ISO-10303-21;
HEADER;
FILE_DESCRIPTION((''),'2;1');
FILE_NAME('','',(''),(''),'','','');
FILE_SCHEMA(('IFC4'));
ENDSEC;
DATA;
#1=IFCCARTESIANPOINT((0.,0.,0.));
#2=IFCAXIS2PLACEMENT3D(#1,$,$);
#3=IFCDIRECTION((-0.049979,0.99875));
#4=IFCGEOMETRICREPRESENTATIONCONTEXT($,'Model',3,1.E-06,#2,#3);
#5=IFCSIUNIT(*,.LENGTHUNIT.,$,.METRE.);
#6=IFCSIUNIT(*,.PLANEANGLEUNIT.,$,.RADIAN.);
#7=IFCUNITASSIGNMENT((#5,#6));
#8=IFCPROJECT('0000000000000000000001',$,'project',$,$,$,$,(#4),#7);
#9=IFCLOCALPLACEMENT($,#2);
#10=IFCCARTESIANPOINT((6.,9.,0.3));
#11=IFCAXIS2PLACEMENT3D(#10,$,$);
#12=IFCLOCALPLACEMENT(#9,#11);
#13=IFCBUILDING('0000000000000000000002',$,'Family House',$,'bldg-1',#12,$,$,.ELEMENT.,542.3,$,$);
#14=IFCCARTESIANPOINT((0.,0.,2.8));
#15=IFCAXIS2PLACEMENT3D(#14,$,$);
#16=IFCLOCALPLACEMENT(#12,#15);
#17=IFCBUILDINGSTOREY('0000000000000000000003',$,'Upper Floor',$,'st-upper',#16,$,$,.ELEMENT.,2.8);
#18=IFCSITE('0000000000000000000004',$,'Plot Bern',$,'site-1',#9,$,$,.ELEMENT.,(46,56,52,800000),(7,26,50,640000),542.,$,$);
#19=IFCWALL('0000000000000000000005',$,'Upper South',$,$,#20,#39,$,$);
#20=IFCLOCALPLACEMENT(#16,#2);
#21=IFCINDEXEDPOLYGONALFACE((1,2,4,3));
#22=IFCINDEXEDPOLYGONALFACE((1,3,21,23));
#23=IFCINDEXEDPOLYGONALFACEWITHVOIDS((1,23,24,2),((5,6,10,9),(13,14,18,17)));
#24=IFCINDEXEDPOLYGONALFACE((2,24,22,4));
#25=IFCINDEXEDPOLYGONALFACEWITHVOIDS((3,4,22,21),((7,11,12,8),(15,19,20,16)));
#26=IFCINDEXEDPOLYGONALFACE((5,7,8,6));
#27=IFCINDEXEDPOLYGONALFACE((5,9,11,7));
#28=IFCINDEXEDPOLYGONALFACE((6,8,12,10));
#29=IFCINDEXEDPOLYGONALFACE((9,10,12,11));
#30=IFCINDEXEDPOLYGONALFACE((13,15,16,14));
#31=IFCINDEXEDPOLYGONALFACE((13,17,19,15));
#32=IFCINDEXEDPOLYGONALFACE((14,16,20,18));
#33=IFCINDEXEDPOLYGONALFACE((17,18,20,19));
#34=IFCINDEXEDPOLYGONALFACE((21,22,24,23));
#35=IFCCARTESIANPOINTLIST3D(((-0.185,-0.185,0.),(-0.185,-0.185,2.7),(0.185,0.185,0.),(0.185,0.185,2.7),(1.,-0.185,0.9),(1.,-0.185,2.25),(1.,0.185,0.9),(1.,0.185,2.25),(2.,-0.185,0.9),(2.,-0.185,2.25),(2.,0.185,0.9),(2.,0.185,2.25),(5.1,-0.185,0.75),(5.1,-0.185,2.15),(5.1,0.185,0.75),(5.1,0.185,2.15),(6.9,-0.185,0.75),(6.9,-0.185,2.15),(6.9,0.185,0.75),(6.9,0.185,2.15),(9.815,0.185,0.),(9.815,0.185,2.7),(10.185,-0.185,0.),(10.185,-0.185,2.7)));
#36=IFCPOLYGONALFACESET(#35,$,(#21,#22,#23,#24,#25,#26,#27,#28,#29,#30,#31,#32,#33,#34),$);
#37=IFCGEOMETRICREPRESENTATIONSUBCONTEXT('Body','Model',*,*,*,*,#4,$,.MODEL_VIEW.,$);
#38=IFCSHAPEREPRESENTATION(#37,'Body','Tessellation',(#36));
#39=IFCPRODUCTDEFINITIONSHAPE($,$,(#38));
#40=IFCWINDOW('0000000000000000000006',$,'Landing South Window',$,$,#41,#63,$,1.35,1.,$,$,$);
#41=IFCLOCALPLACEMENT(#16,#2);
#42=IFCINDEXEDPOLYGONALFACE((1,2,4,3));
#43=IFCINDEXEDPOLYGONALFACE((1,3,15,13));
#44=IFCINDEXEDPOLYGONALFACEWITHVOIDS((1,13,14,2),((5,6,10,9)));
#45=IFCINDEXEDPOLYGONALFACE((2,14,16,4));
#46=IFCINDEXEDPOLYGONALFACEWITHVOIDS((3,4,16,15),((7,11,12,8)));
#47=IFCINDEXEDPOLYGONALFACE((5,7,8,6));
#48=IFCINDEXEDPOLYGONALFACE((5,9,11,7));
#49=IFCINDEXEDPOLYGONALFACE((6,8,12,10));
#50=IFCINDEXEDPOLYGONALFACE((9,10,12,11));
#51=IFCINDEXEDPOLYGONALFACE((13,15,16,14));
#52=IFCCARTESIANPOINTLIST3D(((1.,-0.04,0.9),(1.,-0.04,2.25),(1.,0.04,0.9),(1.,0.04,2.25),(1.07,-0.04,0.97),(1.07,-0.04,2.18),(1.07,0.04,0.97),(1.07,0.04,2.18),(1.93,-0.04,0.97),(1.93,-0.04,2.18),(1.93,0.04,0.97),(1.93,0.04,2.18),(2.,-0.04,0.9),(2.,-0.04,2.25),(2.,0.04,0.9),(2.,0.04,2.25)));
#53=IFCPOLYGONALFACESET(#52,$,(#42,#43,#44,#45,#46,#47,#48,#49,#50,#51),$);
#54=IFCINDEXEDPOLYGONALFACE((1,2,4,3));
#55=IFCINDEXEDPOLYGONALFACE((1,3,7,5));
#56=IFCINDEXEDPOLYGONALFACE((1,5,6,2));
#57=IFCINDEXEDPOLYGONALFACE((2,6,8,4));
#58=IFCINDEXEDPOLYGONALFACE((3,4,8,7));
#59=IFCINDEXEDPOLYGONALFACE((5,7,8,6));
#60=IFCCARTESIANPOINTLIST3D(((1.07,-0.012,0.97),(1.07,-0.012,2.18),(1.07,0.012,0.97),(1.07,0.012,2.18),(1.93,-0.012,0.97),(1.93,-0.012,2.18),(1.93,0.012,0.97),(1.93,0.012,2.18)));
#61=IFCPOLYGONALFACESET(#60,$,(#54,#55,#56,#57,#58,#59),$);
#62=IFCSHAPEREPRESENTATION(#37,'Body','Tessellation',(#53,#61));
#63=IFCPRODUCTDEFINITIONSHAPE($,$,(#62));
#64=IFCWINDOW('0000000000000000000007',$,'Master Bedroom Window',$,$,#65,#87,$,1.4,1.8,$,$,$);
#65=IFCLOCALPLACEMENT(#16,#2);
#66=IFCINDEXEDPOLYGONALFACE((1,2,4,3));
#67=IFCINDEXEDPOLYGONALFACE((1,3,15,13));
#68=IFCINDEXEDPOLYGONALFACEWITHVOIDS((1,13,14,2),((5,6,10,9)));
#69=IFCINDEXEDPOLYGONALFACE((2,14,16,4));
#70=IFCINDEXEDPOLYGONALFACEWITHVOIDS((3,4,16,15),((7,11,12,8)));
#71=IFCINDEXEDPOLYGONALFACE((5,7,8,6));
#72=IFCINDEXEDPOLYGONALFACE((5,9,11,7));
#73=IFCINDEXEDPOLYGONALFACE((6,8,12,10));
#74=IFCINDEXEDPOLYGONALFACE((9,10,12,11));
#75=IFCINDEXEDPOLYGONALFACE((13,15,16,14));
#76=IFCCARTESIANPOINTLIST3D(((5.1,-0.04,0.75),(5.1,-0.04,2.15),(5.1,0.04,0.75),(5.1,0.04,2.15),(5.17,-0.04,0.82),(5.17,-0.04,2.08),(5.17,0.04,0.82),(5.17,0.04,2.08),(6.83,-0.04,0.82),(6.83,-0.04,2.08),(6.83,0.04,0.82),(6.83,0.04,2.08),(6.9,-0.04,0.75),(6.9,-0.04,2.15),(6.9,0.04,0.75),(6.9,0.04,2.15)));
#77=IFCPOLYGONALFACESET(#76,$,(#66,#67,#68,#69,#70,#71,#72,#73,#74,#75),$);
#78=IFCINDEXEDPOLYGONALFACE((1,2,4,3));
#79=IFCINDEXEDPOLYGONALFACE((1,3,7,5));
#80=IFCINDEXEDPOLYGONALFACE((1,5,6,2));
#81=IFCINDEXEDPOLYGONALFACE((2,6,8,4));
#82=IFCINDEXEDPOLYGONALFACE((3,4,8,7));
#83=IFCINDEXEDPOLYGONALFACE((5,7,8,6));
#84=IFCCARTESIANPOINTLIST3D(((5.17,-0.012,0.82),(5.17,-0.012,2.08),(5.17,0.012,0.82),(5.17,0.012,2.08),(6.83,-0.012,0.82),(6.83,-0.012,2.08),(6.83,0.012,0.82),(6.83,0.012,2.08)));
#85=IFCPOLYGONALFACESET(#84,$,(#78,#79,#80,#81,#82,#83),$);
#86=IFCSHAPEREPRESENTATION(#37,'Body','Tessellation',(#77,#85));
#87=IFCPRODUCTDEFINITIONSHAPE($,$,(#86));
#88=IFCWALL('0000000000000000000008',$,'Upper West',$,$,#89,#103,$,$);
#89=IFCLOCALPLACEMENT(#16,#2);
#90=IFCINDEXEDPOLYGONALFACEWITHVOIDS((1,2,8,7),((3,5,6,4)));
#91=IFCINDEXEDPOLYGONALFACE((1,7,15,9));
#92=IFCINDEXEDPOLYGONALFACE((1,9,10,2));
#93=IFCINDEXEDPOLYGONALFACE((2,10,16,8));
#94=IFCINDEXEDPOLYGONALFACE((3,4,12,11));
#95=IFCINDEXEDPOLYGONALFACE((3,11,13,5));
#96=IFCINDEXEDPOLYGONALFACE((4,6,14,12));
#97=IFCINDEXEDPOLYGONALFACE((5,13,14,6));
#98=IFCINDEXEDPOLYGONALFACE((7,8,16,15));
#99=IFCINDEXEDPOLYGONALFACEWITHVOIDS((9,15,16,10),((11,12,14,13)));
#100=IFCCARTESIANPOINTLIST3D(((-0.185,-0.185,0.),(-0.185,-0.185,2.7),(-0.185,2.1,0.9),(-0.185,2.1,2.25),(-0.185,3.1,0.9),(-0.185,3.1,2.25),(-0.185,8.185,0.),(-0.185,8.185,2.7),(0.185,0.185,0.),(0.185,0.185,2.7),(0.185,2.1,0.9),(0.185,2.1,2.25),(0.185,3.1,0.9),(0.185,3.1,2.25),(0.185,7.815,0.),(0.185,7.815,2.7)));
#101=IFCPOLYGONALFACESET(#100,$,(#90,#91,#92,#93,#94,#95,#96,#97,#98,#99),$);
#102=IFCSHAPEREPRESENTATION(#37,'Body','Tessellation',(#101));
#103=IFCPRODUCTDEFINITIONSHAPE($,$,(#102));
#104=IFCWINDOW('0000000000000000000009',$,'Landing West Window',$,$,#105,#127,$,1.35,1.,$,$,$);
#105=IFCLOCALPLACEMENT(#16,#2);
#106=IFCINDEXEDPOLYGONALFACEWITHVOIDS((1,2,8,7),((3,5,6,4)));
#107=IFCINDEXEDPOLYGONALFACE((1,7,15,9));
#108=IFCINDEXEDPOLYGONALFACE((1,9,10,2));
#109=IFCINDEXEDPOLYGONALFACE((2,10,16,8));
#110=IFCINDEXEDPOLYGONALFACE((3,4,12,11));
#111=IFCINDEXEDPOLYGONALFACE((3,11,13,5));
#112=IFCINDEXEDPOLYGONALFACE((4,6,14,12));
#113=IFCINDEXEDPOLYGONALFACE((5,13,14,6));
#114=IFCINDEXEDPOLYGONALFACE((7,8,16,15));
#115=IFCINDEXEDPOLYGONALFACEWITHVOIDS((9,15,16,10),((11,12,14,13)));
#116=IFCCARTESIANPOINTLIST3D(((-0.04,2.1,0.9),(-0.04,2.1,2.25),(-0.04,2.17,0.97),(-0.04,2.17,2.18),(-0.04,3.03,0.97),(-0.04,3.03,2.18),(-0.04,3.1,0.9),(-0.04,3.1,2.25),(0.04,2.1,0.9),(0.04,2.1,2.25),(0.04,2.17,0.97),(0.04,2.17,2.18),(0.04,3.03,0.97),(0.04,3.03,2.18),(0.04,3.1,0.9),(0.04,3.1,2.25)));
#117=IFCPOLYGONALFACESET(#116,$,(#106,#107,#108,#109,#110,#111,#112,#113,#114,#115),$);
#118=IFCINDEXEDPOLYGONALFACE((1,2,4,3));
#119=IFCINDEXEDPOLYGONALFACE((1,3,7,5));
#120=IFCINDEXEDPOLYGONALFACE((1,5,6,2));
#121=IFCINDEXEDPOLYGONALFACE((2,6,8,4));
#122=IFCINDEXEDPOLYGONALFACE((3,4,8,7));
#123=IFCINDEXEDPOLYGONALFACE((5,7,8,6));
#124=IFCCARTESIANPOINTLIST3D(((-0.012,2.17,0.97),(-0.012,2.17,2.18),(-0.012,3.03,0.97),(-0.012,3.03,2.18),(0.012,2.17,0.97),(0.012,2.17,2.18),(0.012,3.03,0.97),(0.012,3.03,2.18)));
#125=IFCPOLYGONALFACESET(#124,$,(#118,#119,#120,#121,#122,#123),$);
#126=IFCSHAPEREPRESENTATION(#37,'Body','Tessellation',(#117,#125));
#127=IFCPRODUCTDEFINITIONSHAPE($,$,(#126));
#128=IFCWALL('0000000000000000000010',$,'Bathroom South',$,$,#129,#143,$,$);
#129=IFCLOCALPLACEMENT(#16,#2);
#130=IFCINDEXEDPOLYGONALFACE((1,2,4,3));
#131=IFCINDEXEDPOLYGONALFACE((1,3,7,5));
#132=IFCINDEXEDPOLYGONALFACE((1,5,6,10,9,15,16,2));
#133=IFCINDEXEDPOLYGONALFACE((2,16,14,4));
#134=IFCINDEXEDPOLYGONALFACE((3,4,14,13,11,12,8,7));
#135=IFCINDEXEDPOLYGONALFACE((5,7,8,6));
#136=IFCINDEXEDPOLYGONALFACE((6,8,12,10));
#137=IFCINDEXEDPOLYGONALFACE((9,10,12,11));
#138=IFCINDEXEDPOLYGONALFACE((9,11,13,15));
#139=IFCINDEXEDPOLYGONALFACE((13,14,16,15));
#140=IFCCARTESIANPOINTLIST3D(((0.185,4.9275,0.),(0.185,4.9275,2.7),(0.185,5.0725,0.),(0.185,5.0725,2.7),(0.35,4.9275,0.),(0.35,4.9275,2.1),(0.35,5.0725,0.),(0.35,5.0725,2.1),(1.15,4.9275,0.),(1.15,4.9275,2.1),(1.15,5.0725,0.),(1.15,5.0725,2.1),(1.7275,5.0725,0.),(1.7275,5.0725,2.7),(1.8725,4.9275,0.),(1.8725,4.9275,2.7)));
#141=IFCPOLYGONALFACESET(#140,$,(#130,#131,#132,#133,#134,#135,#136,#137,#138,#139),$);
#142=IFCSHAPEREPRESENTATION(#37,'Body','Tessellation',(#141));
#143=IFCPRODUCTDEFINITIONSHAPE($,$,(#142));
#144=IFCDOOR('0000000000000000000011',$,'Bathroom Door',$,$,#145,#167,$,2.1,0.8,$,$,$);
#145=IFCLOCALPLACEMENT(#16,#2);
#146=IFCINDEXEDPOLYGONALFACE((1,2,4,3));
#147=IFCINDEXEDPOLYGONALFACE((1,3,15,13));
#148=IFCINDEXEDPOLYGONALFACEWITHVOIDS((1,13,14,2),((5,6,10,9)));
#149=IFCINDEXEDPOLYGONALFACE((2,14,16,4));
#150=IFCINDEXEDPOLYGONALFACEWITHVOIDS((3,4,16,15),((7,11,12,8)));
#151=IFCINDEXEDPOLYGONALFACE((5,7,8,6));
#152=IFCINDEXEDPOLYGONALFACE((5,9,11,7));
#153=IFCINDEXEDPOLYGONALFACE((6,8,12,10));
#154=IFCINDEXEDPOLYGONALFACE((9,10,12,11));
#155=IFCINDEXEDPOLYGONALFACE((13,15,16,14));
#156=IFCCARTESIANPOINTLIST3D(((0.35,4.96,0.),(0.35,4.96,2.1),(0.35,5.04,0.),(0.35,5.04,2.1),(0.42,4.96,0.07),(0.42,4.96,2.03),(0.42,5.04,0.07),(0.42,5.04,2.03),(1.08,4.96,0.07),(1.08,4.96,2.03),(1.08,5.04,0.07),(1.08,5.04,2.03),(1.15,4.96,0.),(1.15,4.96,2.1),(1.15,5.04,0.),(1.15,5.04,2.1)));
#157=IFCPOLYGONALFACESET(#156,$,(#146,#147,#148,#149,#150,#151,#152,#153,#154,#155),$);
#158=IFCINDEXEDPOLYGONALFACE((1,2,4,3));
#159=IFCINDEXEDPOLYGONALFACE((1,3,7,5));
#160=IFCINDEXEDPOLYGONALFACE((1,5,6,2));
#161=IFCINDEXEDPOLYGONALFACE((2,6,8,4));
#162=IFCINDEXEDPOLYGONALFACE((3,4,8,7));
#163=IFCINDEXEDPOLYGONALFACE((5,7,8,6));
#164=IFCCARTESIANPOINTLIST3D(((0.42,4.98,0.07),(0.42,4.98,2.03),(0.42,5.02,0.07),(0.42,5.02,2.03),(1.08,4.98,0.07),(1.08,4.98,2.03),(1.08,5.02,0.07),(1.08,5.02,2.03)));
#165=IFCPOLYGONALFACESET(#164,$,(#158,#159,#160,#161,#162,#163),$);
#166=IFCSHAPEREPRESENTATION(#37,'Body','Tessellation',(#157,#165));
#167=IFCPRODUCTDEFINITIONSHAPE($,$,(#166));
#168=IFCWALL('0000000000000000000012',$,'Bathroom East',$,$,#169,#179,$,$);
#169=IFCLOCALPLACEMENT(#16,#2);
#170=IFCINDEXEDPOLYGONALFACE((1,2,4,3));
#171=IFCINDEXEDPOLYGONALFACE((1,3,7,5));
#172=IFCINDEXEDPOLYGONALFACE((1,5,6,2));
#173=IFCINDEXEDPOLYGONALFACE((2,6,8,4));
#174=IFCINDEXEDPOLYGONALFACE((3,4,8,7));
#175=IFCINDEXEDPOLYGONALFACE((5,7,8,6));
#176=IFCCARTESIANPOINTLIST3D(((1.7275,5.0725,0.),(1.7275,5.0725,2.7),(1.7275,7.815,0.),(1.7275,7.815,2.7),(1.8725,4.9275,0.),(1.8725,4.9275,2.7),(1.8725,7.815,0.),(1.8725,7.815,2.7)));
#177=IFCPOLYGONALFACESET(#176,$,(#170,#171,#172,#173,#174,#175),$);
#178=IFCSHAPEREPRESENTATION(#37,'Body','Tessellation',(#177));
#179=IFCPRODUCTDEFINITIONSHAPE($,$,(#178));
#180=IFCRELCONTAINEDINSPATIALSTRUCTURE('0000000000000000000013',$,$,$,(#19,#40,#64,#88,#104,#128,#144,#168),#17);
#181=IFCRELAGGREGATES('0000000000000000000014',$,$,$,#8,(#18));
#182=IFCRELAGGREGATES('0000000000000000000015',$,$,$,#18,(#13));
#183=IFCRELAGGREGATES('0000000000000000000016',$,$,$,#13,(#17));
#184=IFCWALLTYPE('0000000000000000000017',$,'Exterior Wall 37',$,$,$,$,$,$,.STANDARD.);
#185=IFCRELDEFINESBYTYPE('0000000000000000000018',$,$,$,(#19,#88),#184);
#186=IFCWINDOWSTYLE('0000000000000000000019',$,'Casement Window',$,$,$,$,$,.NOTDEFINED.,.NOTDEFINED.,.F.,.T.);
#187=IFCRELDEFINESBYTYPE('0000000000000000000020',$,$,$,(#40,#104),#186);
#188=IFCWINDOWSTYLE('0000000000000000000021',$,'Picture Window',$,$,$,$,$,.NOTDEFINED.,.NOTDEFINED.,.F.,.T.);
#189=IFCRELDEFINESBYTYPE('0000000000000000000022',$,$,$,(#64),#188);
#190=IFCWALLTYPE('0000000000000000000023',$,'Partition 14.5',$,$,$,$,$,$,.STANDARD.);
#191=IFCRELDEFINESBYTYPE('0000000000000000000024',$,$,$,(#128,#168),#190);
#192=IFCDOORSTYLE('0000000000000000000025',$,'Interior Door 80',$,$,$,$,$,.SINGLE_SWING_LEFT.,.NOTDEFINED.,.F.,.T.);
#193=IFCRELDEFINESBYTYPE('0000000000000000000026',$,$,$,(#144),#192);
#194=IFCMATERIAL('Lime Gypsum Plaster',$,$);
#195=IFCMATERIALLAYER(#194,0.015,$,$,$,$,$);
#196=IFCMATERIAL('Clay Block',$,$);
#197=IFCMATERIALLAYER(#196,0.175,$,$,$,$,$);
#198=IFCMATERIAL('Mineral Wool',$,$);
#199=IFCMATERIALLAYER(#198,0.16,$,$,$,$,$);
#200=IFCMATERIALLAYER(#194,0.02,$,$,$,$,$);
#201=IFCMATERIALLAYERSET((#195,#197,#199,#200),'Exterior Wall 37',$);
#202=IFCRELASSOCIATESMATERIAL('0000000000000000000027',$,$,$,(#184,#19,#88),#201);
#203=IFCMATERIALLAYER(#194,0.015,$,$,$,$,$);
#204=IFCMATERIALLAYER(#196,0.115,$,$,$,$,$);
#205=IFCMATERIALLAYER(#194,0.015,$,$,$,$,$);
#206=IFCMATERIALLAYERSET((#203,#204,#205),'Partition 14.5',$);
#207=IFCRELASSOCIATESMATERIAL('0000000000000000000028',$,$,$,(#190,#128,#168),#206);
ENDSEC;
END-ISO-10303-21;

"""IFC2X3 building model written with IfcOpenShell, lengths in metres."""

from ifc_helpers import new_model, si_unit, direction, frame, frame_2d, origin, origin_2d, place, context, subcontext, project, spatial, polyline, rectangle, outline, extrude, material, layer, layer_set, layer_usage, type_object, element, fill, save


model = new_model("IFC2X3")

# Units and contexts
model_context = context("Model", 3, precision=1e-06, world=origin(), true_north=direction((-0.049979, 0.99875)))
body_context = subcontext(model_context, "Body", "Model", "MODEL_VIEW")
ifc_project = project(units=[si_unit("LENGTHUNIT", "METRE"), si_unit("PLANEANGLEUNIT", "RADIAN")], contexts=[model_context])

# Site, building, storey
site_placement = place(None, origin())
site = spatial("IfcSite", under=ifc_project, at=site_placement, Name="Plot Bern", ObjectType="site-1", CompositionType="ELEMENT", RefLatitude=(46, 56, 52, 800000), RefLongitude=(7, 26, 50, 640000), RefElevation=542.0)
building_placement = place(site_placement, frame((6.0, 9.0, 0.3)))
building = spatial("IfcBuilding", under=site, at=building_placement, Name="Family House", ObjectType="bldg-1", CompositionType="ELEMENT", ElevationOfRefHeight=542.3)
storey_placement = place(building_placement, frame((0.0, 0.0, 2.8)))
storey = spatial("IfcBuildingStorey", under=building, at=storey_placement, Name="Upper Floor", ObjectType="st-upper", CompositionType="ELEMENT", Elevation=2.8)

# Shared definitions
ifc_material_1 = material(Name="Mineral Wool")

# Shared definitions
ifc_material_2 = material(Name="Lime Gypsum Plaster")
ifc_layer_1 = layer(ifc_material_2, 0.015)
ifc_material_3 = material(Name="Clay Block")
ifc_layer_2 = layer(ifc_material_3, 0.175)
ifc_layer_3 = layer(ifc_material_1, 0.16)
ifc_layer_4 = layer(ifc_material_2, 0.02)
ifc_layer_set_1 = layer_set([ifc_layer_1, ifc_layer_2, ifc_layer_3, ifc_layer_4], Name="Exterior Wall 37")
wall_type_1 = type_object("IfcWallType", Name="Exterior Wall 37", PredefinedType="STANDARD", material=ifc_layer_set_1)

# Shared definitions
window_style_1 = type_object("IfcWindowStyle", Name="Casement Window", ConstructionType="NOTDEFINED", OperationType="NOTDEFINED", ParameterTakesPrecedence=False, Sizeable=True)

# Wall, openings, windows
ifc_layer_usage_1 = layer_usage(ifc_layer_set_1, "AXIS2", "NEGATIVE", 0.185)
wall_1_placement = place(storey_placement, origin())
wall_1 = element("IfcWall", 1, at=wall_1_placement, inside=storey, type_object=wall_type_1, material=ifc_layer_usage_1, Name="Upper South", context=body_context, shape_type="SweptSolid", body=[
    extrude(outline(polyline([(-0.185, -0.185), (10.185, -0.185), (9.815, 0.185), (0.185, 0.185), (-0.185, -0.185)])), origin(), (0.0, 0.0, 1.0), 2.7),
])
opening_1_placement = place(wall_1_placement, frame((1.5, 0.0, 0.9), z_axis=(0.0, 0.0, 1.0), x_axis=(1.0, 0.0, 0.0)))
opening_1 = element("IfcOpeningElement", 2, at=opening_1_placement, cuts=wall_1, context=body_context, shape_type="SweptSolid", body=[
    extrude(rectangle(XDim=1.0, YDim=0.37, at=origin_2d()), origin(), (0.0, 0.0, 1.0), 1.35),
])
opening_2_placement = place(wall_1_placement, frame((6.0, 0.0, 0.75), z_axis=(0.0, 0.0, 1.0), x_axis=(1.0, 0.0, 0.0)))
opening_2 = element("IfcOpeningElement", 3, at=opening_2_placement, cuts=wall_1, context=body_context, shape_type="SweptSolid", body=[
    extrude(rectangle(XDim=1.8, YDim=0.37, at=origin_2d()), origin(), (0.0, 0.0, 1.0), 1.4),
])
window_1_placement = place(opening_1_placement, frame((0.0, 0.0, 0.0), z_axis=(0.0, -1.0, 0.0), x_axis=(1.0, 0.0, 0.0)))
window_1 = element("IfcWindow", 4, at=window_1_placement, inside=storey, type_object=window_style_1, Name="Landing South Window", OverallHeight=1.35, OverallWidth=1.0, context=body_context, shape_type="SweptSolid", body=[
    extrude(outline(polyline([(-0.5, 0.0), (0.5, 0.0), (0.5, 1.35), (-0.5, 1.35), (-0.5, 0.0)]), holes=[polyline([(-0.43, 0.07), (0.43, 0.07), (0.43, 1.28), (-0.43, 1.28), (-0.43, 0.07)])]), frame((0.0, 0.0, -0.04)), (0.0, 0.0, 1.0), 0.08),
    extrude(rectangle(XDim=0.86, YDim=1.21, at=frame_2d((0.0, 0.675))), frame((0.0, 0.0, -0.012)), (0.0, 0.0, 1.0), 0.024),
])
fill(opening_1, window_1)
window_style_2 = type_object("IfcWindowStyle", Name="Picture Window", ConstructionType="NOTDEFINED", OperationType="NOTDEFINED", ParameterTakesPrecedence=False, Sizeable=True)
window_2_placement = place(opening_2_placement, frame((0.0, 0.0, 0.0), z_axis=(0.0, -1.0, 0.0), x_axis=(1.0, 0.0, 0.0)))
window_2 = element("IfcWindow", 5, at=window_2_placement, inside=storey, type_object=window_style_2, Name="Master Bedroom Window", OverallHeight=1.4, OverallWidth=1.8, context=body_context, shape_type="SweptSolid", body=[
    extrude(outline(polyline([(-0.9, 0.0), (0.9, 0.0), (0.9, 1.4), (-0.9, 1.4), (-0.9, 0.0)]), holes=[polyline([(-0.83, 0.07), (0.83, 0.07), (0.83, 1.33), (-0.83, 1.33), (-0.83, 0.07)])]), frame((0.0, 0.0, -0.04)), (0.0, 0.0, 1.0), 0.08),
    extrude(rectangle(XDim=1.66, YDim=1.26, at=frame_2d((0.0, 0.7))), frame((0.0, 0.0, -0.012)), (0.0, 0.0, 1.0), 0.024),
])
fill(opening_2, window_2)

# Wall, opening, window
ifc_layer_usage_2 = layer_usage(ifc_layer_set_1, "AXIS2", "NEGATIVE", 0.185)
wall_2_placement = place(storey_placement, origin())
wall_2 = element("IfcWall", 6, at=wall_2_placement, inside=storey, type_object=wall_type_1, material=ifc_layer_usage_2, Name="Upper West", context=body_context, shape_type="SweptSolid", body=[
    extrude(outline(polyline([(-0.185, 8.185), (-0.185, -0.185), (0.185, 0.185), (0.185, 7.815), (-0.185, 8.185)])), origin(), (0.0, 0.0, 1.0), 2.7),
])
opening_3_placement = place(wall_2_placement, frame((0.0, 2.6, 0.9), z_axis=(0.0, 0.0, 1.0), x_axis=(0.0, -1.0, 0.0)))
opening_3 = element("IfcOpeningElement", 7, at=opening_3_placement, cuts=wall_2, context=body_context, shape_type="SweptSolid", body=[
    extrude(rectangle(XDim=1.0, YDim=0.37, at=origin_2d()), origin(), (0.0, 0.0, 1.0), 1.35),
])
window_3_placement = place(opening_3_placement, frame((0.0, 0.0, 0.0), z_axis=(0.0, -1.0, 0.0), x_axis=(1.0, 0.0, 0.0)))
window_3 = element("IfcWindow", 8, at=window_3_placement, inside=storey, type_object=window_style_1, Name="Landing West Window", OverallHeight=1.35, OverallWidth=1.0, context=body_context, shape_type="SweptSolid", body=[
    extrude(outline(polyline([(-0.5, 0.0), (0.5, 0.0), (0.5, 1.35), (-0.5, 1.35), (-0.5, 0.0)]), holes=[polyline([(-0.43, 0.07), (0.43, 0.07), (0.43, 1.28), (-0.43, 1.28), (-0.43, 0.07)])]), frame((0.0, 0.0, -0.04)), (0.0, 0.0, 1.0), 0.08),
    extrude(rectangle(XDim=0.86, YDim=1.21, at=frame_2d((0.0, 0.675))), frame((0.0, 0.0, -0.012)), (0.0, 0.0, 1.0), 0.024),
])
fill(opening_3, window_3)

# Wall, opening, door
ifc_layer_5 = layer(ifc_material_2, 0.015)
ifc_layer_6 = layer(ifc_material_3, 0.115)
ifc_layer_7 = layer(ifc_material_2, 0.015)
ifc_layer_set_2 = layer_set([ifc_layer_5, ifc_layer_6, ifc_layer_7], Name="Partition 14.5")
ifc_layer_usage_3 = layer_usage(ifc_layer_set_2, "AXIS2", "NEGATIVE", 0.0725)
wall_type_2 = type_object("IfcWallType", Name="Partition 14.5", PredefinedType="STANDARD", material=ifc_layer_set_2)
wall_3_placement = place(storey_placement, origin())
wall_3 = element("IfcWall", 9, at=wall_3_placement, inside=storey, type_object=wall_type_2, material=ifc_layer_usage_3, Name="Bathroom South", context=body_context, shape_type="SweptSolid", body=[
    extrude(outline(polyline([(0.185, 4.9275), (1.8725, 4.9275), (1.7275, 5.0725), (0.185, 5.0725), (0.185, 4.9275)])), origin(), (0.0, 0.0, 1.0), 2.7),
])
opening_4_placement = place(wall_3_placement, frame((0.75, 5.0, 0.0), z_axis=(0.0, 0.0, 1.0), x_axis=(1.0, 0.0, 0.0)))
opening_4 = element("IfcOpeningElement", 10, at=opening_4_placement, cuts=wall_3, context=body_context, shape_type="SweptSolid", body=[
    extrude(rectangle(XDim=0.8, YDim=0.145, at=origin_2d()), origin(), (0.0, 0.0, 1.0), 2.1),
])
door_style_1 = type_object("IfcDoorStyle", Name="Interior Door 80", ConstructionType="NOTDEFINED", OperationType="SINGLE_SWING_LEFT", ParameterTakesPrecedence=False, Sizeable=True)
door_1_placement = place(opening_4_placement, frame((0.0, 0.0, 0.0), z_axis=(0.0, -1.0, 0.0), x_axis=(1.0, 0.0, 0.0)))
door_1 = element("IfcDoor", 11, at=door_1_placement, inside=storey, type_object=door_style_1, Name="Bathroom Door", OverallHeight=2.1, OverallWidth=0.8, context=body_context, shape_type="SweptSolid", body=[
    extrude(outline(polyline([(-0.4, 0.0), (0.4, 0.0), (0.4, 2.1), (-0.4, 2.1), (-0.4, 0.0)]), holes=[polyline([(-0.33, 0.07), (0.33, 0.07), (0.33, 2.03), (-0.33, 2.03), (-0.33, 0.07)])]), frame((0.0, 0.0, -0.04)), (0.0, 0.0, 1.0), 0.08),
    extrude(rectangle(XDim=0.66, YDim=1.96, at=frame_2d((0.0, 1.05))), frame((0.0, 0.0, -0.02)), (0.0, 0.0, 1.0), 0.04),
])
fill(opening_4, door_1)

# Wall
ifc_layer_usage_4 = layer_usage(ifc_layer_set_2, "AXIS2", "NEGATIVE", 0.0725)
wall_4_placement = place(storey_placement, origin())
element("IfcWall", 12, at=wall_4_placement, inside=storey, type_object=wall_type_2, material=ifc_layer_usage_4, Name="Bathroom East", context=body_context, shape_type="SweptSolid", body=[
    extrude(outline(polyline([(1.8725, 4.9275), (1.8725, 7.815), (1.7275, 7.815), (1.7275, 5.0725), (1.8725, 4.9275)])), origin(), (0.0, 0.0, 1.0), 2.7),
])

save(model, "model.ifc")
